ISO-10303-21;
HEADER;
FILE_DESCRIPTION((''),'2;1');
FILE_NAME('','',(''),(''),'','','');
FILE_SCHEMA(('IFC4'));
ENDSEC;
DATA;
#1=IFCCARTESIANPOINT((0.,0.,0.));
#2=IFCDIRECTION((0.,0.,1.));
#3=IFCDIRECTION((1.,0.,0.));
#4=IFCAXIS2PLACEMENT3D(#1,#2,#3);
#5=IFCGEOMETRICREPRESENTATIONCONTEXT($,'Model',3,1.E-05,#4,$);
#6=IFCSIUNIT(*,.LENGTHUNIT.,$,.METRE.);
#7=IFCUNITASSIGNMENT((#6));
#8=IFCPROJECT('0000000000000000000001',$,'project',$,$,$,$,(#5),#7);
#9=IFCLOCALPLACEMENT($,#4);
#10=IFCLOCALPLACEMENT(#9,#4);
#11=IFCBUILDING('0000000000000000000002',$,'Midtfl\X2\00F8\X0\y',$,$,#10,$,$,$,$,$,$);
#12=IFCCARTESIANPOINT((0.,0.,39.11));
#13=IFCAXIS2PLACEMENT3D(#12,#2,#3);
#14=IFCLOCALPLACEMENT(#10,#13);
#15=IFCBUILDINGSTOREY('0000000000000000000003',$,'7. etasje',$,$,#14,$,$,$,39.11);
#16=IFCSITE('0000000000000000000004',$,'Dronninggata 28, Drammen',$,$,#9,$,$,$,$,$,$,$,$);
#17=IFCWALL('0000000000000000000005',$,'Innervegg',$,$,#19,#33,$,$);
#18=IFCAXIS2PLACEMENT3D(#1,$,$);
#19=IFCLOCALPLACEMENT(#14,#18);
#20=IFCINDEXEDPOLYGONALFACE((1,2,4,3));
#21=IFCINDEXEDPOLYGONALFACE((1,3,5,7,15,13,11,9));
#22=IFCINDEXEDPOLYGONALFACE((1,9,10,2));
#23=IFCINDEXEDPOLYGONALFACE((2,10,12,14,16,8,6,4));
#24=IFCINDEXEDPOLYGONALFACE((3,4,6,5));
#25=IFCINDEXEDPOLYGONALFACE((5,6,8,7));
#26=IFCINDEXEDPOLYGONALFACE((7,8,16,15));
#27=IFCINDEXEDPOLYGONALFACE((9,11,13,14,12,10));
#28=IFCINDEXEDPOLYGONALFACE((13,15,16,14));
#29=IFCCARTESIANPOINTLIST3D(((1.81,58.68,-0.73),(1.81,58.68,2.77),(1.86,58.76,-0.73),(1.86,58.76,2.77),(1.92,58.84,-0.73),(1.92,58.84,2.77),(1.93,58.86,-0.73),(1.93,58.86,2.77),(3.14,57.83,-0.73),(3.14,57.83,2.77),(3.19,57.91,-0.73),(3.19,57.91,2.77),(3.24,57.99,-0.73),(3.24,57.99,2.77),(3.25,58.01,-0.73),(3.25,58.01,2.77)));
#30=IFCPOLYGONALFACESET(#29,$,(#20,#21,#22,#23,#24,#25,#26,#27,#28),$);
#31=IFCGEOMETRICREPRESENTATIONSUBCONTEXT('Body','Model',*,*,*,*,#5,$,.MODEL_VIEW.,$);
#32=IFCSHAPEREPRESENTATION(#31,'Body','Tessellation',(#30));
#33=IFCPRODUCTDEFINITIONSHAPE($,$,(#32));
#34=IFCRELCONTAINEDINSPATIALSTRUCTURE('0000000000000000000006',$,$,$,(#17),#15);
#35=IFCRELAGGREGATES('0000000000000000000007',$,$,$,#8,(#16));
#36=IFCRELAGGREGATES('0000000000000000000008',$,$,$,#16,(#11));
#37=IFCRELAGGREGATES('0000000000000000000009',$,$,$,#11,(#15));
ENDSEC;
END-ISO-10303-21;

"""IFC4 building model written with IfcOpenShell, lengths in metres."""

from ifc_helpers import new_model, si_unit, frame, origin_with_axes, place, context, subcontext, project, spatial, polyline, outline, extrude, element, save


model = new_model("IFC4")

# Units and contexts
model_context = context("Model", 3, precision=1e-05, world=origin_with_axes())
body_context = subcontext(model_context, "Body", "Model", "MODEL_VIEW")
ifc_project = project(units=[si_unit("LENGTHUNIT", "METRE")], contexts=[model_context])

# Site, building, storey
site_placement = place(None, origin_with_axes())
site = spatial("IfcSite", under=ifc_project, at=site_placement, Name="Dronninggata 28, Drammen")
building_placement = place(site_placement, origin_with_axes())
building = spatial("IfcBuilding", under=site, at=building_placement, Name="Midtfløy")
storey_placement = place(building_placement, frame((0.0, 0.0, 39.11), z_axis=(0.0, 0.0, 1.0), x_axis=(1.0, 0.0, 0.0)))
storey = spatial("IfcBuildingStorey", under=building, at=storey_placement, Name="7. etasje", Elevation=39.11)

# Wall
wall_1_placement = place(storey_placement, frame((0.0, 0.0, -39.11), z_axis=(0.0, 0.0, 1.0), x_axis=(1.0, 0.0, 0.0)))
element("IfcWall", 1, at=wall_1_placement, inside=storey, Name="Innervegg", context=body_context, shape_type="SweptSolid", body=[
    extrude(outline(polyline([(1.93, 58.86), (3.25, 58.01), (3.24, 57.99), (3.19, 57.91), (3.14, 57.83), (1.81, 58.68), (1.86, 58.76), (1.92, 58.84), (1.93, 58.86)])), frame((0.0, 0.0, 38.38)), (0.0, 0.0, 1.0), 3.5),
])

save(model, "model.ifc")
